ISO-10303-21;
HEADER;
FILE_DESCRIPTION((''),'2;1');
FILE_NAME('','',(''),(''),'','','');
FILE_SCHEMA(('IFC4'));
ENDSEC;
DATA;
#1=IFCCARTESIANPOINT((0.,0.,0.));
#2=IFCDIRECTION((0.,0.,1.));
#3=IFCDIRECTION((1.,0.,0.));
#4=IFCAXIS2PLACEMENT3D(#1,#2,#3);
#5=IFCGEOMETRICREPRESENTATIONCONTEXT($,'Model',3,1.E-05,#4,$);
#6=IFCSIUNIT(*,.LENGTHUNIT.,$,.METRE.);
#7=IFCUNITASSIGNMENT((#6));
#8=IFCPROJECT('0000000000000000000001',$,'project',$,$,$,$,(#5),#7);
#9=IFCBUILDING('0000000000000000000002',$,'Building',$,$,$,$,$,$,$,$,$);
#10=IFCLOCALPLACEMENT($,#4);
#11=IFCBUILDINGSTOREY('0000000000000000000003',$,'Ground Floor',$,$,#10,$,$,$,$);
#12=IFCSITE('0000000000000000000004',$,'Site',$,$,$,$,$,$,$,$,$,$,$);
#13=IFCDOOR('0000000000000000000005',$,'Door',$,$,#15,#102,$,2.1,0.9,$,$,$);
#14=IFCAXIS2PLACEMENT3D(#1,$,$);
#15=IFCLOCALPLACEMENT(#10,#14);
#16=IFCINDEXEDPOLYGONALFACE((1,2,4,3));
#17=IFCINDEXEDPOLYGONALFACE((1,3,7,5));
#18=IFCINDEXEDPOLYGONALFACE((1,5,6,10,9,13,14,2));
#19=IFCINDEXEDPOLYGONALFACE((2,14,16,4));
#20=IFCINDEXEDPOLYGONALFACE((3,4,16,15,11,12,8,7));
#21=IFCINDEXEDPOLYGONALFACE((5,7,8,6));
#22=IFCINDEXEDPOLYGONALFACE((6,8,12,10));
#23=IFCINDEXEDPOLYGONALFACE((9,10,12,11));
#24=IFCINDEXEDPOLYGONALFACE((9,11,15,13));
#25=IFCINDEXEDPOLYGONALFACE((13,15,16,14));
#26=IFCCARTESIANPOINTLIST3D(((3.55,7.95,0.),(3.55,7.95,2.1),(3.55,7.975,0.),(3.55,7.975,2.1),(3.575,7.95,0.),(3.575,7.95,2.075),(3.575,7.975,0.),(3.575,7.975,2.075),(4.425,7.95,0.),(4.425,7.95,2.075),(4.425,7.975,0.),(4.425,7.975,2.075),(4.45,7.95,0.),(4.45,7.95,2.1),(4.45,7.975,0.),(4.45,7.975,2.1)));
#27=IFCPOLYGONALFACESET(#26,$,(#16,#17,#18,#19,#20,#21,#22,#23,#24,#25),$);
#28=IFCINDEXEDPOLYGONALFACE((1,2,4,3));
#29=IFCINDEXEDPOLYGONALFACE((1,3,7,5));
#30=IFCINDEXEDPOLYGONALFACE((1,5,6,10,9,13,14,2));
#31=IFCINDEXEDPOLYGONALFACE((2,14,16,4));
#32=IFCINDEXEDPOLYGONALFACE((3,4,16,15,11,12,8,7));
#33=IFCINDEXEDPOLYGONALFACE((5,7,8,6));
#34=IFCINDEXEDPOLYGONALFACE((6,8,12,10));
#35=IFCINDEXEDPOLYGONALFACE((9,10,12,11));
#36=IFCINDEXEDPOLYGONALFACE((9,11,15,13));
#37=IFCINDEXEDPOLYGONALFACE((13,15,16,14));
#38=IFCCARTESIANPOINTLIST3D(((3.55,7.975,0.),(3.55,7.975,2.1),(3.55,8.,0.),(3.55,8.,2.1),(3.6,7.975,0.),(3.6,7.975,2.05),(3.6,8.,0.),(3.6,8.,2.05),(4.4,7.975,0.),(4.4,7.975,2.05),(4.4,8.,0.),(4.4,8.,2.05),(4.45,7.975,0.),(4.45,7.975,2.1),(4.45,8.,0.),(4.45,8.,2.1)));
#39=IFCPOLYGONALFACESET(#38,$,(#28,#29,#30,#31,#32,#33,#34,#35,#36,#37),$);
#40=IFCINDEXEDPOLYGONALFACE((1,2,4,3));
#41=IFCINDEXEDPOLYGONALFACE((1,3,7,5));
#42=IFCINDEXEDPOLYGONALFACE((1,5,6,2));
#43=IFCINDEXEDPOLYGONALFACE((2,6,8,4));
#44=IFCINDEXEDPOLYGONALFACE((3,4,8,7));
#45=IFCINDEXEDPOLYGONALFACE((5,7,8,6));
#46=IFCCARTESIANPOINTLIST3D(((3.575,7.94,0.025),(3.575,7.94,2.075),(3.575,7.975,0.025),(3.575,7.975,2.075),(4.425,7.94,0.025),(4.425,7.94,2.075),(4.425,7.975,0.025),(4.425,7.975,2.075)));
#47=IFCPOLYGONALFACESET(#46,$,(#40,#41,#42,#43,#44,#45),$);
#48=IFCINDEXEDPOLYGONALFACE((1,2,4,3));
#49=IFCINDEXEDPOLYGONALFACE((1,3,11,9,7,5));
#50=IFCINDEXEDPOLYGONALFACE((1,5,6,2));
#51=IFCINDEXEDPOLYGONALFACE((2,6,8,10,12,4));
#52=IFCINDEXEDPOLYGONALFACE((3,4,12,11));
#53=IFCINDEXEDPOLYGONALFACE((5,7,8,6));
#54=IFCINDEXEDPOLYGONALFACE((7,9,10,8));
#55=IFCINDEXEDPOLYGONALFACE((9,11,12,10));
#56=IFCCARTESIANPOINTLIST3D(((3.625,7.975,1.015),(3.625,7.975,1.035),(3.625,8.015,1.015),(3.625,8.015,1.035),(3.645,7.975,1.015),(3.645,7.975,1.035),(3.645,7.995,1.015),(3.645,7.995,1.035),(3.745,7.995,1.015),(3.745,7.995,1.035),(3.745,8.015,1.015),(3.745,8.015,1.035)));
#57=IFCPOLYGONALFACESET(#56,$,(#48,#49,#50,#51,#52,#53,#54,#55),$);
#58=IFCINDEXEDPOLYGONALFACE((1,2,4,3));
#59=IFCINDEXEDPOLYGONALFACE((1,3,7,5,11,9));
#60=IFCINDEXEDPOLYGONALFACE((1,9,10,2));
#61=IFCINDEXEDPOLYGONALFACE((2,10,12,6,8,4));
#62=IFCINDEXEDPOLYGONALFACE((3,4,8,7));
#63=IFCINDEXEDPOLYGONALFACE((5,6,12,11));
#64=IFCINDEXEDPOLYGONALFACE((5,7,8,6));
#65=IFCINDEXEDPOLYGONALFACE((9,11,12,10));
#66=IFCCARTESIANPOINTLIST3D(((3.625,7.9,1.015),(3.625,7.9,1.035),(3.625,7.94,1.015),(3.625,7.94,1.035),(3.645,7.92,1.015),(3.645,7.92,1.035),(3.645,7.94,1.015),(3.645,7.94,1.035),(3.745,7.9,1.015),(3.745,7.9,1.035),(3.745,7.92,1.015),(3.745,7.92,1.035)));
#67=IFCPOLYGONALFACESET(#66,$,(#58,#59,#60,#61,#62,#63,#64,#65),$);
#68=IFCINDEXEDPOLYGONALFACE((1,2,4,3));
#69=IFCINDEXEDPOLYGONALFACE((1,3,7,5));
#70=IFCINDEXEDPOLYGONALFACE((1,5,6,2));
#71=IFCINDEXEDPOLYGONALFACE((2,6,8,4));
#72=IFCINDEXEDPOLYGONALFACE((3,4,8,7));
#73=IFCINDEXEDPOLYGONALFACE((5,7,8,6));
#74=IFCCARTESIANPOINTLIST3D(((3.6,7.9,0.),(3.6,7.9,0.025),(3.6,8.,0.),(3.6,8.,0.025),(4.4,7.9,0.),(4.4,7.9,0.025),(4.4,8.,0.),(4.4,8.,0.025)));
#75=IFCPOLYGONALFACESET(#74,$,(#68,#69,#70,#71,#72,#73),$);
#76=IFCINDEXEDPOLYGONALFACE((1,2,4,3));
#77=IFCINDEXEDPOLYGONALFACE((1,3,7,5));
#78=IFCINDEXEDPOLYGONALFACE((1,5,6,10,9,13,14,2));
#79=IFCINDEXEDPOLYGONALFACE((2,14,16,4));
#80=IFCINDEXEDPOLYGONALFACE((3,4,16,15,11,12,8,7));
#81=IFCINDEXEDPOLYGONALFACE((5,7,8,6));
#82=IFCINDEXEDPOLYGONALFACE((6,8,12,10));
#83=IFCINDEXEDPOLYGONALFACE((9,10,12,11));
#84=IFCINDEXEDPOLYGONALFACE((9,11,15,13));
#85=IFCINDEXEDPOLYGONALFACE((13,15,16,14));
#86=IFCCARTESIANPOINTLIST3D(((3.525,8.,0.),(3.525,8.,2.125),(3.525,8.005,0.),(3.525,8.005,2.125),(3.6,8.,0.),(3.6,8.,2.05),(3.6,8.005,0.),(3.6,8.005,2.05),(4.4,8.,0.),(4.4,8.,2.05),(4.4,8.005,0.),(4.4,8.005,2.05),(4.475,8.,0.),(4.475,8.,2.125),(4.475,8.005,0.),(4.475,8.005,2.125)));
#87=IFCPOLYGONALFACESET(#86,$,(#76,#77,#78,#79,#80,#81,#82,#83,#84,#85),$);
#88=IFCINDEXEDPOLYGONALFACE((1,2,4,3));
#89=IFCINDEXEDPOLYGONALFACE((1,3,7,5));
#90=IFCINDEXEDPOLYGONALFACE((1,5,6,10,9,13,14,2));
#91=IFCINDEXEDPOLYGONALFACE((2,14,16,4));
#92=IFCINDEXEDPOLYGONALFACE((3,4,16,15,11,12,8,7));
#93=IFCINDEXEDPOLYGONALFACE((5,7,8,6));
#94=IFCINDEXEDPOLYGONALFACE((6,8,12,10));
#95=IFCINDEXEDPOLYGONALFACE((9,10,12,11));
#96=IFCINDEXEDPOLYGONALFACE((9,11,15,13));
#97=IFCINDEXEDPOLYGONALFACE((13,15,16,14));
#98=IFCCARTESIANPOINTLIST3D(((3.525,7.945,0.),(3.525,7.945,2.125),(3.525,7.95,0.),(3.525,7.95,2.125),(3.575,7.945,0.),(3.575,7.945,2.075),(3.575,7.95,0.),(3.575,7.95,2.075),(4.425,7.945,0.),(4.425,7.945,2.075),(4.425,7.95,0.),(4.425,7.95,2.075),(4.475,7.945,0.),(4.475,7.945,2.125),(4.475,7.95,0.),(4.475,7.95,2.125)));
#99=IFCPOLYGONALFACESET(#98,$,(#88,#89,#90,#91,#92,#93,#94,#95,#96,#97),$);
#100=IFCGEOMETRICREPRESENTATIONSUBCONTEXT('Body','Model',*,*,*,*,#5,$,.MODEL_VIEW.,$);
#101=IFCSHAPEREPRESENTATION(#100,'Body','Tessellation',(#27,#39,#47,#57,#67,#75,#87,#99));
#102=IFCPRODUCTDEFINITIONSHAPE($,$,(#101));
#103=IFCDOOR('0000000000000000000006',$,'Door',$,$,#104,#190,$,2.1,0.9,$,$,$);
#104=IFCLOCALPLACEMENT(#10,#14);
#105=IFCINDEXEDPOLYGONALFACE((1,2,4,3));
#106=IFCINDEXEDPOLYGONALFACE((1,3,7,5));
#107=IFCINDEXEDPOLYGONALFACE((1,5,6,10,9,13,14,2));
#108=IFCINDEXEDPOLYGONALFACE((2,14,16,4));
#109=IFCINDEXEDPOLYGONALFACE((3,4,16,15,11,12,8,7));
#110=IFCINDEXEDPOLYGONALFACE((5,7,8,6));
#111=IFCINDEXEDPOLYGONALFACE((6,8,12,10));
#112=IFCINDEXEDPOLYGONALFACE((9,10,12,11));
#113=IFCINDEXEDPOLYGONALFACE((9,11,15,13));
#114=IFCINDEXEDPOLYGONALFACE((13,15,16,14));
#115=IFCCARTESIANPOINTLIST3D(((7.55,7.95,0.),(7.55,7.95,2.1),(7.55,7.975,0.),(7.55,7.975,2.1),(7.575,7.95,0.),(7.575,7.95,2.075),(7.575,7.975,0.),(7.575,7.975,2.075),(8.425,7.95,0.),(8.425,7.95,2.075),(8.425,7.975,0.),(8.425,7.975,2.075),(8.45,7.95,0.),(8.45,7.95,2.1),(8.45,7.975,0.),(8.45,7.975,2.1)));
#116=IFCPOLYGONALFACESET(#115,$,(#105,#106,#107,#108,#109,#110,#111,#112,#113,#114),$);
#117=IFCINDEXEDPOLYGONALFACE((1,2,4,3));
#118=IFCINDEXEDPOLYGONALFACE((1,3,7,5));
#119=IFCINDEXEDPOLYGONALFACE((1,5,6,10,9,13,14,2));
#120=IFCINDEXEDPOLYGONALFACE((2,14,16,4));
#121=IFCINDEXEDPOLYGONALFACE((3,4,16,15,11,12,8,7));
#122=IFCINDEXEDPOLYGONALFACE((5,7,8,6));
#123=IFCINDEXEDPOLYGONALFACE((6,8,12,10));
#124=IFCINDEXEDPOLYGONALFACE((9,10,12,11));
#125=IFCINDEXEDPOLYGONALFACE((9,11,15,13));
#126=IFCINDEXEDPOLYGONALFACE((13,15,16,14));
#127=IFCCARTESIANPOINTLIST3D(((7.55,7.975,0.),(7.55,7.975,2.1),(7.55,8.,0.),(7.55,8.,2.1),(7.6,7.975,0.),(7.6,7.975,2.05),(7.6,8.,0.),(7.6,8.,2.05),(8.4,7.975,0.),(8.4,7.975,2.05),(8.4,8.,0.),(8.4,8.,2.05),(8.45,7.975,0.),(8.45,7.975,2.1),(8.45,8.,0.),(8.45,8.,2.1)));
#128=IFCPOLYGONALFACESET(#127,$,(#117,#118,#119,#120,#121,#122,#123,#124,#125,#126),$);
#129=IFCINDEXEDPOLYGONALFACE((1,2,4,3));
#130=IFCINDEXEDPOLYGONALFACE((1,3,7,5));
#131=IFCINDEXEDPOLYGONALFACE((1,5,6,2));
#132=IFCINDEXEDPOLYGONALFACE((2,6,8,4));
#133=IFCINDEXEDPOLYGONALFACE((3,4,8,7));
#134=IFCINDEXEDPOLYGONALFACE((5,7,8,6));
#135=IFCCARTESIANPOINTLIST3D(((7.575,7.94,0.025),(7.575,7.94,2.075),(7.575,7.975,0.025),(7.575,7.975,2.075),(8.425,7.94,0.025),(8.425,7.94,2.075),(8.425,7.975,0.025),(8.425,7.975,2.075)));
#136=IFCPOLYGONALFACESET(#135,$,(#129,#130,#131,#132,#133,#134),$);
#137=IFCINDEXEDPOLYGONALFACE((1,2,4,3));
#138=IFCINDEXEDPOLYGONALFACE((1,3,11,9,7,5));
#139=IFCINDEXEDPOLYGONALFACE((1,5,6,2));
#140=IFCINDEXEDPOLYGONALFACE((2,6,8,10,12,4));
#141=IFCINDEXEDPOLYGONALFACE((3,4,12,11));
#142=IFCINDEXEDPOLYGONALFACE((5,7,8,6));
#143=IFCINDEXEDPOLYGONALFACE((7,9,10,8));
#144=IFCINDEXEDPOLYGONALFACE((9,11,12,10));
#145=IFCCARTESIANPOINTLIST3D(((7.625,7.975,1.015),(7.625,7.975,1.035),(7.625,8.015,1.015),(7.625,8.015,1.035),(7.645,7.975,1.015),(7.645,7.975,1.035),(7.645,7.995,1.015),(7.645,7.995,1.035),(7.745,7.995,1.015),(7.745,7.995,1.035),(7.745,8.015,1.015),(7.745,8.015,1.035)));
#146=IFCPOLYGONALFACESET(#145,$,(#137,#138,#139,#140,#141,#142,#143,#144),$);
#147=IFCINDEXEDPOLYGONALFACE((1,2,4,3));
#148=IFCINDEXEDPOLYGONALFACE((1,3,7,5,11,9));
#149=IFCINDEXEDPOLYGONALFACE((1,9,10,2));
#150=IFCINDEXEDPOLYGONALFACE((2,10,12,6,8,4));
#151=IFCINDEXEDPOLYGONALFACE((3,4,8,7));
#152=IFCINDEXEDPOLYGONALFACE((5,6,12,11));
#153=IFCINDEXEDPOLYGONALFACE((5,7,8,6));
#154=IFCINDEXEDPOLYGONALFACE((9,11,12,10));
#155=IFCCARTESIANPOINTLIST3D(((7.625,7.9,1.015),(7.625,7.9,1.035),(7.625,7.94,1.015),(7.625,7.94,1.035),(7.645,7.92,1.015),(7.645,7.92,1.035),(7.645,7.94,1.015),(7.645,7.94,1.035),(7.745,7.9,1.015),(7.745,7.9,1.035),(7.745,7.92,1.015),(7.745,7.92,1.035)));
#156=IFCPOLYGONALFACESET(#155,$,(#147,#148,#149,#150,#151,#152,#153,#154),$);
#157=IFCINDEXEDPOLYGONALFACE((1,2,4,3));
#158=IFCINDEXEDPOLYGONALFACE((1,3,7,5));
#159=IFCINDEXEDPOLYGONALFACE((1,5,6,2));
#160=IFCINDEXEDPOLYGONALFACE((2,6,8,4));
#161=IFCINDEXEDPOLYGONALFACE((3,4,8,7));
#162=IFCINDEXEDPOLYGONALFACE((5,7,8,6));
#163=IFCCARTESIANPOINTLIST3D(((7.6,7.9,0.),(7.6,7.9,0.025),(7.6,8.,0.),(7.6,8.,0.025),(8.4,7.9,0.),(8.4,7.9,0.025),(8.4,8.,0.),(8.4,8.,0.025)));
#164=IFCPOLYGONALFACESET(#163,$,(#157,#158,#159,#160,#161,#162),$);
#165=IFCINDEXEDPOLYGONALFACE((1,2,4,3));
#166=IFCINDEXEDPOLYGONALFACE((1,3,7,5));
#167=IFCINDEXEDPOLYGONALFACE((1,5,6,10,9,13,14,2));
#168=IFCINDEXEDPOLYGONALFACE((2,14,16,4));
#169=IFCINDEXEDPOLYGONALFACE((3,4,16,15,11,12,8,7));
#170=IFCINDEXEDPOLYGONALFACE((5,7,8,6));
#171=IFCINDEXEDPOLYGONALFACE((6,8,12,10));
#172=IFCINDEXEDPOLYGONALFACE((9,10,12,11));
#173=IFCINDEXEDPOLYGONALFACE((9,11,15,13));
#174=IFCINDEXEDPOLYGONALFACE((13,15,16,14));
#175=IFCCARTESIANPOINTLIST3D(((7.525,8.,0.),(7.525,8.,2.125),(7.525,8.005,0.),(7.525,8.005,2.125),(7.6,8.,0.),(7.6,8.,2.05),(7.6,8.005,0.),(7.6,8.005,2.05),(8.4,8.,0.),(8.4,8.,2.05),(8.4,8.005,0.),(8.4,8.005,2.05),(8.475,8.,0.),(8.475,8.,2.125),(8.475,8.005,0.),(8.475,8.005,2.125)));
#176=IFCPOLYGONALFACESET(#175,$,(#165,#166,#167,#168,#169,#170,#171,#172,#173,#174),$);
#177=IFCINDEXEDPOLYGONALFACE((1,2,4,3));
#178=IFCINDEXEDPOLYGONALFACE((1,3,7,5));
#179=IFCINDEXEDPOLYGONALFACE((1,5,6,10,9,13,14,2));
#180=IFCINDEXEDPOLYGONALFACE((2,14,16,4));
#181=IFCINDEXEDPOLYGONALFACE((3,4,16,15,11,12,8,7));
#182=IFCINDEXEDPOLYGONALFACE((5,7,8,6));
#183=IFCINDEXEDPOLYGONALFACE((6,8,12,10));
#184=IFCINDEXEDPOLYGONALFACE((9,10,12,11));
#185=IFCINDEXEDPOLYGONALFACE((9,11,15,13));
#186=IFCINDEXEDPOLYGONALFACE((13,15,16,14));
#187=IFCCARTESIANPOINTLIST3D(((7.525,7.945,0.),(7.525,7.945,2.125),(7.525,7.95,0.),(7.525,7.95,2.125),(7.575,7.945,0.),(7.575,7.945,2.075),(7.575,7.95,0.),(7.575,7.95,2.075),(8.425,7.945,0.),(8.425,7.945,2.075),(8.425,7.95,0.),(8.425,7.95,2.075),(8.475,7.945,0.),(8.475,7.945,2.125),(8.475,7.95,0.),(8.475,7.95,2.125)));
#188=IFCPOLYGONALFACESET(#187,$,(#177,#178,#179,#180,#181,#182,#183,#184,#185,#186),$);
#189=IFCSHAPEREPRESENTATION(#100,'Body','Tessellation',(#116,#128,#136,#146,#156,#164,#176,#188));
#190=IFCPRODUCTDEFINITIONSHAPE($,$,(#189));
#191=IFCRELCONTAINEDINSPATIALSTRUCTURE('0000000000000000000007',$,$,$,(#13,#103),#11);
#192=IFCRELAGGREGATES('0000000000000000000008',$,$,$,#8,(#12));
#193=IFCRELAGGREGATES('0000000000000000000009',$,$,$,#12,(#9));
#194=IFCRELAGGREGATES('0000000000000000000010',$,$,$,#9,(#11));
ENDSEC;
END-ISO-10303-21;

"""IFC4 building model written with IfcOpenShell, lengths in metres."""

from ifc_helpers import new_model, si_unit, frame, origin_with_axes, place, context, subcontext, project, spatial, line, indexed_curve, outline, extrude, element, save


model = new_model("IFC4")

# Units and contexts
model_context = context("Model", 3, precision=1e-05, world=origin_with_axes())
body_context = subcontext(model_context, "Body", "Model", "MODEL_VIEW")
ifc_project = project(units=[si_unit("LENGTHUNIT", "METRE")], contexts=[model_context])

# Site, building, storey
site = spatial("IfcSite", under=ifc_project, Name="Site")
building = spatial("IfcBuilding", under=site, Name="Building")
storey_placement = place(None, origin_with_axes())
storey = spatial("IfcBuildingStorey", under=building, at=storey_placement, Name="Ground Floor")

# Doors
door_1_placement = place(storey_placement, frame((4.45, 8.0, 0.0), z_axis=(0.0, 0.0, 1.0), x_axis=(-1.0, 0.0, 0.0)))
element("IfcDoor", 1, at=door_1_placement, inside=storey, Name="Door", OverallHeight=2.1, OverallWidth=0.9, context=body_context, shape_type="SweptSolid", body=[
    extrude(outline(indexed_curve([(0.0, 0.0), (0.0, 2.1), (0.9, 2.1), (0.9, 0.0), (0.875, 0.0), (0.875, 2.075), (0.025, 2.075), (0.025, 0.0)], segments=[line(1, 2, 3, 4, 5, 6, 7, 8, 1)])), frame((0.0, 0.025, 0.0), z_axis=(0.0, -1.0, 0.0), x_axis=(1.0, 0.0, 0.0)), (0.0, 0.0, -1.0), 0.025),
    extrude(outline(indexed_curve([(0.0, 0.0), (0.0, 2.1), (0.9, 2.1), (0.9, 0.0), (0.85, 0.0), (0.85, 2.05), (0.05, 2.05), (0.05, 0.0)], segments=[line(1, 2, 3, 4, 5, 6, 7, 8, 1)])), frame((0.0, 0.0, 0.0), z_axis=(0.0, -1.0, 0.0), x_axis=(1.0, 0.0, 0.0)), (0.0, 0.0, -1.0), 0.025),
    extrude(outline(indexed_curve([(0.0, 0.0), (0.85, 0.0), (0.85, 0.035), (0.0, 0.035)], segments=[line(1, 2, 3, 4, 1)])), frame((0.025, 0.025, 0.025), z_axis=(0.0, 0.0, 1.0), x_axis=(1.0, 0.0, 0.0)), (0.0, 0.0, 1.0), 2.05),
    extrude(outline(indexed_curve([(0.0, 0.0), (0.0, -0.04), (-0.12, -0.04), (-0.12, -0.02), (-0.02, -0.02), (-0.02, 0.0)], segments=[line(1, 2, 3, 4, 5, 6, 1)])), frame((0.825, 0.025, 1.015), z_axis=(0.0, 0.0, 1.0), x_axis=(1.0, 0.0, 0.0)), (0.0, 0.0, 1.0), 0.02),
    extrude(outline(indexed_curve([(0.0, 0.0), (0.0, 0.04), (-0.12, 0.04), (-0.12, 0.02), (-0.02, 0.02), (-0.02, 0.0)], segments=[line(1, 2, 3, 4, 5, 6, 1)])), frame((0.825, 0.06, 1.015), z_axis=(0.0, 0.0, 1.0), x_axis=(1.0, 0.0, 0.0)), (0.0, 0.0, 1.0), 0.02),
    extrude(outline(indexed_curve([(0.0, 0.0), (0.8, 0.0), (0.8, 0.1), (0.0, 0.1)], segments=[line(1, 2, 3, 4, 1)])), frame((0.05, 0.0, 0.0), z_axis=(0.0, 0.0, 1.0), x_axis=(1.0, 0.0, 0.0)), (0.0, 0.0, 1.0), 0.025),
    extrude(outline(indexed_curve([(0.0, 0.0), (0.0, 2.125), (0.95, 2.125), (0.95, 0.0), (0.875, 0.0), (0.875, 2.05), (0.075, 2.05), (0.075, 0.0)], segments=[line(1, 2, 3, 4, 5, 6, 7, 8, 1)])), frame((-0.025, -0.005, 0.0), z_axis=(0.0, -1.0, 0.0), x_axis=(1.0, 0.0, 0.0)), (0.0, 0.0, -1.0), 0.005),
    extrude(outline(indexed_curve([(0.0, 0.0), (0.0, 2.125), (0.95, 2.125), (0.95, 0.0), (0.9, 0.0), (0.9, 2.075), (0.05, 2.075), (0.05, 0.0)], segments=[line(1, 2, 3, 4, 5, 6, 7, 8, 1)])), frame((-0.025, 0.05, 0.0), z_axis=(0.0, -1.0, 0.0), x_axis=(1.0, 0.0, 0.0)), (0.0, 0.0, -1.0), 0.005),
])
door_2_placement = place(storey_placement, frame((8.45, 8.0, 0.0), z_axis=(0.0, 0.0, 1.0), x_axis=(-1.0, 0.0, 0.0)))
element("IfcDoor", 2, at=door_2_placement, inside=storey, Name="Door", OverallHeight=2.1, OverallWidth=0.9, context=body_context, shape_type="SweptSolid", body=[
    extrude(outline(indexed_curve([(0.0, 0.0), (0.0, 2.1), (0.9, 2.1), (0.9, 0.0), (0.875, 0.0), (0.875, 2.075), (0.025, 2.075), (0.025, 0.0)], segments=[line(1, 2, 3, 4, 5, 6, 7, 8, 1)])), frame((0.0, 0.025, 0.0), z_axis=(0.0, -1.0, 0.0), x_axis=(1.0, 0.0, 0.0)), (0.0, 0.0, -1.0), 0.025),
    extrude(outline(indexed_curve([(0.0, 0.0), (0.0, 2.1), (0.9, 2.1), (0.9, 0.0), (0.85, 0.0), (0.85, 2.05), (0.05, 2.05), (0.05, 0.0)], segments=[line(1, 2, 3, 4, 5, 6, 7, 8, 1)])), frame((0.0, 0.0, 0.0), z_axis=(0.0, -1.0, 0.0), x_axis=(1.0, 0.0, 0.0)), (0.0, 0.0, -1.0), 0.025),
    extrude(outline(indexed_curve([(0.0, 0.0), (0.85, 0.0), (0.85, 0.035), (0.0, 0.035)], segments=[line(1, 2, 3, 4, 1)])), frame((0.025, 0.025, 0.025), z_axis=(0.0, 0.0, 1.0), x_axis=(1.0, 0.0, 0.0)), (0.0, 0.0, 1.0), 2.05),
    extrude(outline(indexed_curve([(0.0, 0.0), (0.0, -0.04), (-0.12, -0.04), (-0.12, -0.02), (-0.02, -0.02), (-0.02, 0.0)], segments=[line(1, 2, 3, 4, 5, 6, 1)])), frame((0.825, 0.025, 1.015), z_axis=(0.0, 0.0, 1.0), x_axis=(1.0, 0.0, 0.0)), (0.0, 0.0, 1.0), 0.02),
    extrude(outline(indexed_curve([(0.0, 0.0), (0.0, 0.04), (-0.12, 0.04), (-0.12, 0.02), (-0.02, 0.02), (-0.02, 0.0)], segments=[line(1, 2, 3, 4, 5, 6, 1)])), frame((0.825, 0.06, 1.015), z_axis=(0.0, 0.0, 1.0), x_axis=(1.0, 0.0, 0.0)), (0.0, 0.0, 1.0), 0.02),
    extrude(outline(indexed_curve([(0.0, 0.0), (0.8, 0.0), (0.8, 0.1), (0.0, 0.1)], segments=[line(1, 2, 3, 4, 1)])), frame((0.05, 0.0, 0.0), z_axis=(0.0, 0.0, 1.0), x_axis=(1.0, 0.0, 0.0)), (0.0, 0.0, 1.0), 0.025),
    extrude(outline(indexed_curve([(0.0, 0.0), (0.0, 2.125), (0.95, 2.125), (0.95, 0.0), (0.875, 0.0), (0.875, 2.05), (0.075, 2.05), (0.075, 0.0)], segments=[line(1, 2, 3, 4, 5, 6, 7, 8, 1)])), frame((-0.025, -0.005, 0.0), z_axis=(0.0, -1.0, 0.0), x_axis=(1.0, 0.0, 0.0)), (0.0, 0.0, -1.0), 0.005),
    extrude(outline(indexed_curve([(0.0, 0.0), (0.0, 2.125), (0.95, 2.125), (0.95, 0.0), (0.9, 0.0), (0.9, 2.075), (0.05, 2.075), (0.05, 0.0)], segments=[line(1, 2, 3, 4, 5, 6, 7, 8, 1)])), frame((-0.025, 0.05, 0.0), z_axis=(0.0, -1.0, 0.0), x_axis=(1.0, 0.0, 0.0)), (0.0, 0.0, -1.0), 0.005),
])

save(model, "model.ifc")
